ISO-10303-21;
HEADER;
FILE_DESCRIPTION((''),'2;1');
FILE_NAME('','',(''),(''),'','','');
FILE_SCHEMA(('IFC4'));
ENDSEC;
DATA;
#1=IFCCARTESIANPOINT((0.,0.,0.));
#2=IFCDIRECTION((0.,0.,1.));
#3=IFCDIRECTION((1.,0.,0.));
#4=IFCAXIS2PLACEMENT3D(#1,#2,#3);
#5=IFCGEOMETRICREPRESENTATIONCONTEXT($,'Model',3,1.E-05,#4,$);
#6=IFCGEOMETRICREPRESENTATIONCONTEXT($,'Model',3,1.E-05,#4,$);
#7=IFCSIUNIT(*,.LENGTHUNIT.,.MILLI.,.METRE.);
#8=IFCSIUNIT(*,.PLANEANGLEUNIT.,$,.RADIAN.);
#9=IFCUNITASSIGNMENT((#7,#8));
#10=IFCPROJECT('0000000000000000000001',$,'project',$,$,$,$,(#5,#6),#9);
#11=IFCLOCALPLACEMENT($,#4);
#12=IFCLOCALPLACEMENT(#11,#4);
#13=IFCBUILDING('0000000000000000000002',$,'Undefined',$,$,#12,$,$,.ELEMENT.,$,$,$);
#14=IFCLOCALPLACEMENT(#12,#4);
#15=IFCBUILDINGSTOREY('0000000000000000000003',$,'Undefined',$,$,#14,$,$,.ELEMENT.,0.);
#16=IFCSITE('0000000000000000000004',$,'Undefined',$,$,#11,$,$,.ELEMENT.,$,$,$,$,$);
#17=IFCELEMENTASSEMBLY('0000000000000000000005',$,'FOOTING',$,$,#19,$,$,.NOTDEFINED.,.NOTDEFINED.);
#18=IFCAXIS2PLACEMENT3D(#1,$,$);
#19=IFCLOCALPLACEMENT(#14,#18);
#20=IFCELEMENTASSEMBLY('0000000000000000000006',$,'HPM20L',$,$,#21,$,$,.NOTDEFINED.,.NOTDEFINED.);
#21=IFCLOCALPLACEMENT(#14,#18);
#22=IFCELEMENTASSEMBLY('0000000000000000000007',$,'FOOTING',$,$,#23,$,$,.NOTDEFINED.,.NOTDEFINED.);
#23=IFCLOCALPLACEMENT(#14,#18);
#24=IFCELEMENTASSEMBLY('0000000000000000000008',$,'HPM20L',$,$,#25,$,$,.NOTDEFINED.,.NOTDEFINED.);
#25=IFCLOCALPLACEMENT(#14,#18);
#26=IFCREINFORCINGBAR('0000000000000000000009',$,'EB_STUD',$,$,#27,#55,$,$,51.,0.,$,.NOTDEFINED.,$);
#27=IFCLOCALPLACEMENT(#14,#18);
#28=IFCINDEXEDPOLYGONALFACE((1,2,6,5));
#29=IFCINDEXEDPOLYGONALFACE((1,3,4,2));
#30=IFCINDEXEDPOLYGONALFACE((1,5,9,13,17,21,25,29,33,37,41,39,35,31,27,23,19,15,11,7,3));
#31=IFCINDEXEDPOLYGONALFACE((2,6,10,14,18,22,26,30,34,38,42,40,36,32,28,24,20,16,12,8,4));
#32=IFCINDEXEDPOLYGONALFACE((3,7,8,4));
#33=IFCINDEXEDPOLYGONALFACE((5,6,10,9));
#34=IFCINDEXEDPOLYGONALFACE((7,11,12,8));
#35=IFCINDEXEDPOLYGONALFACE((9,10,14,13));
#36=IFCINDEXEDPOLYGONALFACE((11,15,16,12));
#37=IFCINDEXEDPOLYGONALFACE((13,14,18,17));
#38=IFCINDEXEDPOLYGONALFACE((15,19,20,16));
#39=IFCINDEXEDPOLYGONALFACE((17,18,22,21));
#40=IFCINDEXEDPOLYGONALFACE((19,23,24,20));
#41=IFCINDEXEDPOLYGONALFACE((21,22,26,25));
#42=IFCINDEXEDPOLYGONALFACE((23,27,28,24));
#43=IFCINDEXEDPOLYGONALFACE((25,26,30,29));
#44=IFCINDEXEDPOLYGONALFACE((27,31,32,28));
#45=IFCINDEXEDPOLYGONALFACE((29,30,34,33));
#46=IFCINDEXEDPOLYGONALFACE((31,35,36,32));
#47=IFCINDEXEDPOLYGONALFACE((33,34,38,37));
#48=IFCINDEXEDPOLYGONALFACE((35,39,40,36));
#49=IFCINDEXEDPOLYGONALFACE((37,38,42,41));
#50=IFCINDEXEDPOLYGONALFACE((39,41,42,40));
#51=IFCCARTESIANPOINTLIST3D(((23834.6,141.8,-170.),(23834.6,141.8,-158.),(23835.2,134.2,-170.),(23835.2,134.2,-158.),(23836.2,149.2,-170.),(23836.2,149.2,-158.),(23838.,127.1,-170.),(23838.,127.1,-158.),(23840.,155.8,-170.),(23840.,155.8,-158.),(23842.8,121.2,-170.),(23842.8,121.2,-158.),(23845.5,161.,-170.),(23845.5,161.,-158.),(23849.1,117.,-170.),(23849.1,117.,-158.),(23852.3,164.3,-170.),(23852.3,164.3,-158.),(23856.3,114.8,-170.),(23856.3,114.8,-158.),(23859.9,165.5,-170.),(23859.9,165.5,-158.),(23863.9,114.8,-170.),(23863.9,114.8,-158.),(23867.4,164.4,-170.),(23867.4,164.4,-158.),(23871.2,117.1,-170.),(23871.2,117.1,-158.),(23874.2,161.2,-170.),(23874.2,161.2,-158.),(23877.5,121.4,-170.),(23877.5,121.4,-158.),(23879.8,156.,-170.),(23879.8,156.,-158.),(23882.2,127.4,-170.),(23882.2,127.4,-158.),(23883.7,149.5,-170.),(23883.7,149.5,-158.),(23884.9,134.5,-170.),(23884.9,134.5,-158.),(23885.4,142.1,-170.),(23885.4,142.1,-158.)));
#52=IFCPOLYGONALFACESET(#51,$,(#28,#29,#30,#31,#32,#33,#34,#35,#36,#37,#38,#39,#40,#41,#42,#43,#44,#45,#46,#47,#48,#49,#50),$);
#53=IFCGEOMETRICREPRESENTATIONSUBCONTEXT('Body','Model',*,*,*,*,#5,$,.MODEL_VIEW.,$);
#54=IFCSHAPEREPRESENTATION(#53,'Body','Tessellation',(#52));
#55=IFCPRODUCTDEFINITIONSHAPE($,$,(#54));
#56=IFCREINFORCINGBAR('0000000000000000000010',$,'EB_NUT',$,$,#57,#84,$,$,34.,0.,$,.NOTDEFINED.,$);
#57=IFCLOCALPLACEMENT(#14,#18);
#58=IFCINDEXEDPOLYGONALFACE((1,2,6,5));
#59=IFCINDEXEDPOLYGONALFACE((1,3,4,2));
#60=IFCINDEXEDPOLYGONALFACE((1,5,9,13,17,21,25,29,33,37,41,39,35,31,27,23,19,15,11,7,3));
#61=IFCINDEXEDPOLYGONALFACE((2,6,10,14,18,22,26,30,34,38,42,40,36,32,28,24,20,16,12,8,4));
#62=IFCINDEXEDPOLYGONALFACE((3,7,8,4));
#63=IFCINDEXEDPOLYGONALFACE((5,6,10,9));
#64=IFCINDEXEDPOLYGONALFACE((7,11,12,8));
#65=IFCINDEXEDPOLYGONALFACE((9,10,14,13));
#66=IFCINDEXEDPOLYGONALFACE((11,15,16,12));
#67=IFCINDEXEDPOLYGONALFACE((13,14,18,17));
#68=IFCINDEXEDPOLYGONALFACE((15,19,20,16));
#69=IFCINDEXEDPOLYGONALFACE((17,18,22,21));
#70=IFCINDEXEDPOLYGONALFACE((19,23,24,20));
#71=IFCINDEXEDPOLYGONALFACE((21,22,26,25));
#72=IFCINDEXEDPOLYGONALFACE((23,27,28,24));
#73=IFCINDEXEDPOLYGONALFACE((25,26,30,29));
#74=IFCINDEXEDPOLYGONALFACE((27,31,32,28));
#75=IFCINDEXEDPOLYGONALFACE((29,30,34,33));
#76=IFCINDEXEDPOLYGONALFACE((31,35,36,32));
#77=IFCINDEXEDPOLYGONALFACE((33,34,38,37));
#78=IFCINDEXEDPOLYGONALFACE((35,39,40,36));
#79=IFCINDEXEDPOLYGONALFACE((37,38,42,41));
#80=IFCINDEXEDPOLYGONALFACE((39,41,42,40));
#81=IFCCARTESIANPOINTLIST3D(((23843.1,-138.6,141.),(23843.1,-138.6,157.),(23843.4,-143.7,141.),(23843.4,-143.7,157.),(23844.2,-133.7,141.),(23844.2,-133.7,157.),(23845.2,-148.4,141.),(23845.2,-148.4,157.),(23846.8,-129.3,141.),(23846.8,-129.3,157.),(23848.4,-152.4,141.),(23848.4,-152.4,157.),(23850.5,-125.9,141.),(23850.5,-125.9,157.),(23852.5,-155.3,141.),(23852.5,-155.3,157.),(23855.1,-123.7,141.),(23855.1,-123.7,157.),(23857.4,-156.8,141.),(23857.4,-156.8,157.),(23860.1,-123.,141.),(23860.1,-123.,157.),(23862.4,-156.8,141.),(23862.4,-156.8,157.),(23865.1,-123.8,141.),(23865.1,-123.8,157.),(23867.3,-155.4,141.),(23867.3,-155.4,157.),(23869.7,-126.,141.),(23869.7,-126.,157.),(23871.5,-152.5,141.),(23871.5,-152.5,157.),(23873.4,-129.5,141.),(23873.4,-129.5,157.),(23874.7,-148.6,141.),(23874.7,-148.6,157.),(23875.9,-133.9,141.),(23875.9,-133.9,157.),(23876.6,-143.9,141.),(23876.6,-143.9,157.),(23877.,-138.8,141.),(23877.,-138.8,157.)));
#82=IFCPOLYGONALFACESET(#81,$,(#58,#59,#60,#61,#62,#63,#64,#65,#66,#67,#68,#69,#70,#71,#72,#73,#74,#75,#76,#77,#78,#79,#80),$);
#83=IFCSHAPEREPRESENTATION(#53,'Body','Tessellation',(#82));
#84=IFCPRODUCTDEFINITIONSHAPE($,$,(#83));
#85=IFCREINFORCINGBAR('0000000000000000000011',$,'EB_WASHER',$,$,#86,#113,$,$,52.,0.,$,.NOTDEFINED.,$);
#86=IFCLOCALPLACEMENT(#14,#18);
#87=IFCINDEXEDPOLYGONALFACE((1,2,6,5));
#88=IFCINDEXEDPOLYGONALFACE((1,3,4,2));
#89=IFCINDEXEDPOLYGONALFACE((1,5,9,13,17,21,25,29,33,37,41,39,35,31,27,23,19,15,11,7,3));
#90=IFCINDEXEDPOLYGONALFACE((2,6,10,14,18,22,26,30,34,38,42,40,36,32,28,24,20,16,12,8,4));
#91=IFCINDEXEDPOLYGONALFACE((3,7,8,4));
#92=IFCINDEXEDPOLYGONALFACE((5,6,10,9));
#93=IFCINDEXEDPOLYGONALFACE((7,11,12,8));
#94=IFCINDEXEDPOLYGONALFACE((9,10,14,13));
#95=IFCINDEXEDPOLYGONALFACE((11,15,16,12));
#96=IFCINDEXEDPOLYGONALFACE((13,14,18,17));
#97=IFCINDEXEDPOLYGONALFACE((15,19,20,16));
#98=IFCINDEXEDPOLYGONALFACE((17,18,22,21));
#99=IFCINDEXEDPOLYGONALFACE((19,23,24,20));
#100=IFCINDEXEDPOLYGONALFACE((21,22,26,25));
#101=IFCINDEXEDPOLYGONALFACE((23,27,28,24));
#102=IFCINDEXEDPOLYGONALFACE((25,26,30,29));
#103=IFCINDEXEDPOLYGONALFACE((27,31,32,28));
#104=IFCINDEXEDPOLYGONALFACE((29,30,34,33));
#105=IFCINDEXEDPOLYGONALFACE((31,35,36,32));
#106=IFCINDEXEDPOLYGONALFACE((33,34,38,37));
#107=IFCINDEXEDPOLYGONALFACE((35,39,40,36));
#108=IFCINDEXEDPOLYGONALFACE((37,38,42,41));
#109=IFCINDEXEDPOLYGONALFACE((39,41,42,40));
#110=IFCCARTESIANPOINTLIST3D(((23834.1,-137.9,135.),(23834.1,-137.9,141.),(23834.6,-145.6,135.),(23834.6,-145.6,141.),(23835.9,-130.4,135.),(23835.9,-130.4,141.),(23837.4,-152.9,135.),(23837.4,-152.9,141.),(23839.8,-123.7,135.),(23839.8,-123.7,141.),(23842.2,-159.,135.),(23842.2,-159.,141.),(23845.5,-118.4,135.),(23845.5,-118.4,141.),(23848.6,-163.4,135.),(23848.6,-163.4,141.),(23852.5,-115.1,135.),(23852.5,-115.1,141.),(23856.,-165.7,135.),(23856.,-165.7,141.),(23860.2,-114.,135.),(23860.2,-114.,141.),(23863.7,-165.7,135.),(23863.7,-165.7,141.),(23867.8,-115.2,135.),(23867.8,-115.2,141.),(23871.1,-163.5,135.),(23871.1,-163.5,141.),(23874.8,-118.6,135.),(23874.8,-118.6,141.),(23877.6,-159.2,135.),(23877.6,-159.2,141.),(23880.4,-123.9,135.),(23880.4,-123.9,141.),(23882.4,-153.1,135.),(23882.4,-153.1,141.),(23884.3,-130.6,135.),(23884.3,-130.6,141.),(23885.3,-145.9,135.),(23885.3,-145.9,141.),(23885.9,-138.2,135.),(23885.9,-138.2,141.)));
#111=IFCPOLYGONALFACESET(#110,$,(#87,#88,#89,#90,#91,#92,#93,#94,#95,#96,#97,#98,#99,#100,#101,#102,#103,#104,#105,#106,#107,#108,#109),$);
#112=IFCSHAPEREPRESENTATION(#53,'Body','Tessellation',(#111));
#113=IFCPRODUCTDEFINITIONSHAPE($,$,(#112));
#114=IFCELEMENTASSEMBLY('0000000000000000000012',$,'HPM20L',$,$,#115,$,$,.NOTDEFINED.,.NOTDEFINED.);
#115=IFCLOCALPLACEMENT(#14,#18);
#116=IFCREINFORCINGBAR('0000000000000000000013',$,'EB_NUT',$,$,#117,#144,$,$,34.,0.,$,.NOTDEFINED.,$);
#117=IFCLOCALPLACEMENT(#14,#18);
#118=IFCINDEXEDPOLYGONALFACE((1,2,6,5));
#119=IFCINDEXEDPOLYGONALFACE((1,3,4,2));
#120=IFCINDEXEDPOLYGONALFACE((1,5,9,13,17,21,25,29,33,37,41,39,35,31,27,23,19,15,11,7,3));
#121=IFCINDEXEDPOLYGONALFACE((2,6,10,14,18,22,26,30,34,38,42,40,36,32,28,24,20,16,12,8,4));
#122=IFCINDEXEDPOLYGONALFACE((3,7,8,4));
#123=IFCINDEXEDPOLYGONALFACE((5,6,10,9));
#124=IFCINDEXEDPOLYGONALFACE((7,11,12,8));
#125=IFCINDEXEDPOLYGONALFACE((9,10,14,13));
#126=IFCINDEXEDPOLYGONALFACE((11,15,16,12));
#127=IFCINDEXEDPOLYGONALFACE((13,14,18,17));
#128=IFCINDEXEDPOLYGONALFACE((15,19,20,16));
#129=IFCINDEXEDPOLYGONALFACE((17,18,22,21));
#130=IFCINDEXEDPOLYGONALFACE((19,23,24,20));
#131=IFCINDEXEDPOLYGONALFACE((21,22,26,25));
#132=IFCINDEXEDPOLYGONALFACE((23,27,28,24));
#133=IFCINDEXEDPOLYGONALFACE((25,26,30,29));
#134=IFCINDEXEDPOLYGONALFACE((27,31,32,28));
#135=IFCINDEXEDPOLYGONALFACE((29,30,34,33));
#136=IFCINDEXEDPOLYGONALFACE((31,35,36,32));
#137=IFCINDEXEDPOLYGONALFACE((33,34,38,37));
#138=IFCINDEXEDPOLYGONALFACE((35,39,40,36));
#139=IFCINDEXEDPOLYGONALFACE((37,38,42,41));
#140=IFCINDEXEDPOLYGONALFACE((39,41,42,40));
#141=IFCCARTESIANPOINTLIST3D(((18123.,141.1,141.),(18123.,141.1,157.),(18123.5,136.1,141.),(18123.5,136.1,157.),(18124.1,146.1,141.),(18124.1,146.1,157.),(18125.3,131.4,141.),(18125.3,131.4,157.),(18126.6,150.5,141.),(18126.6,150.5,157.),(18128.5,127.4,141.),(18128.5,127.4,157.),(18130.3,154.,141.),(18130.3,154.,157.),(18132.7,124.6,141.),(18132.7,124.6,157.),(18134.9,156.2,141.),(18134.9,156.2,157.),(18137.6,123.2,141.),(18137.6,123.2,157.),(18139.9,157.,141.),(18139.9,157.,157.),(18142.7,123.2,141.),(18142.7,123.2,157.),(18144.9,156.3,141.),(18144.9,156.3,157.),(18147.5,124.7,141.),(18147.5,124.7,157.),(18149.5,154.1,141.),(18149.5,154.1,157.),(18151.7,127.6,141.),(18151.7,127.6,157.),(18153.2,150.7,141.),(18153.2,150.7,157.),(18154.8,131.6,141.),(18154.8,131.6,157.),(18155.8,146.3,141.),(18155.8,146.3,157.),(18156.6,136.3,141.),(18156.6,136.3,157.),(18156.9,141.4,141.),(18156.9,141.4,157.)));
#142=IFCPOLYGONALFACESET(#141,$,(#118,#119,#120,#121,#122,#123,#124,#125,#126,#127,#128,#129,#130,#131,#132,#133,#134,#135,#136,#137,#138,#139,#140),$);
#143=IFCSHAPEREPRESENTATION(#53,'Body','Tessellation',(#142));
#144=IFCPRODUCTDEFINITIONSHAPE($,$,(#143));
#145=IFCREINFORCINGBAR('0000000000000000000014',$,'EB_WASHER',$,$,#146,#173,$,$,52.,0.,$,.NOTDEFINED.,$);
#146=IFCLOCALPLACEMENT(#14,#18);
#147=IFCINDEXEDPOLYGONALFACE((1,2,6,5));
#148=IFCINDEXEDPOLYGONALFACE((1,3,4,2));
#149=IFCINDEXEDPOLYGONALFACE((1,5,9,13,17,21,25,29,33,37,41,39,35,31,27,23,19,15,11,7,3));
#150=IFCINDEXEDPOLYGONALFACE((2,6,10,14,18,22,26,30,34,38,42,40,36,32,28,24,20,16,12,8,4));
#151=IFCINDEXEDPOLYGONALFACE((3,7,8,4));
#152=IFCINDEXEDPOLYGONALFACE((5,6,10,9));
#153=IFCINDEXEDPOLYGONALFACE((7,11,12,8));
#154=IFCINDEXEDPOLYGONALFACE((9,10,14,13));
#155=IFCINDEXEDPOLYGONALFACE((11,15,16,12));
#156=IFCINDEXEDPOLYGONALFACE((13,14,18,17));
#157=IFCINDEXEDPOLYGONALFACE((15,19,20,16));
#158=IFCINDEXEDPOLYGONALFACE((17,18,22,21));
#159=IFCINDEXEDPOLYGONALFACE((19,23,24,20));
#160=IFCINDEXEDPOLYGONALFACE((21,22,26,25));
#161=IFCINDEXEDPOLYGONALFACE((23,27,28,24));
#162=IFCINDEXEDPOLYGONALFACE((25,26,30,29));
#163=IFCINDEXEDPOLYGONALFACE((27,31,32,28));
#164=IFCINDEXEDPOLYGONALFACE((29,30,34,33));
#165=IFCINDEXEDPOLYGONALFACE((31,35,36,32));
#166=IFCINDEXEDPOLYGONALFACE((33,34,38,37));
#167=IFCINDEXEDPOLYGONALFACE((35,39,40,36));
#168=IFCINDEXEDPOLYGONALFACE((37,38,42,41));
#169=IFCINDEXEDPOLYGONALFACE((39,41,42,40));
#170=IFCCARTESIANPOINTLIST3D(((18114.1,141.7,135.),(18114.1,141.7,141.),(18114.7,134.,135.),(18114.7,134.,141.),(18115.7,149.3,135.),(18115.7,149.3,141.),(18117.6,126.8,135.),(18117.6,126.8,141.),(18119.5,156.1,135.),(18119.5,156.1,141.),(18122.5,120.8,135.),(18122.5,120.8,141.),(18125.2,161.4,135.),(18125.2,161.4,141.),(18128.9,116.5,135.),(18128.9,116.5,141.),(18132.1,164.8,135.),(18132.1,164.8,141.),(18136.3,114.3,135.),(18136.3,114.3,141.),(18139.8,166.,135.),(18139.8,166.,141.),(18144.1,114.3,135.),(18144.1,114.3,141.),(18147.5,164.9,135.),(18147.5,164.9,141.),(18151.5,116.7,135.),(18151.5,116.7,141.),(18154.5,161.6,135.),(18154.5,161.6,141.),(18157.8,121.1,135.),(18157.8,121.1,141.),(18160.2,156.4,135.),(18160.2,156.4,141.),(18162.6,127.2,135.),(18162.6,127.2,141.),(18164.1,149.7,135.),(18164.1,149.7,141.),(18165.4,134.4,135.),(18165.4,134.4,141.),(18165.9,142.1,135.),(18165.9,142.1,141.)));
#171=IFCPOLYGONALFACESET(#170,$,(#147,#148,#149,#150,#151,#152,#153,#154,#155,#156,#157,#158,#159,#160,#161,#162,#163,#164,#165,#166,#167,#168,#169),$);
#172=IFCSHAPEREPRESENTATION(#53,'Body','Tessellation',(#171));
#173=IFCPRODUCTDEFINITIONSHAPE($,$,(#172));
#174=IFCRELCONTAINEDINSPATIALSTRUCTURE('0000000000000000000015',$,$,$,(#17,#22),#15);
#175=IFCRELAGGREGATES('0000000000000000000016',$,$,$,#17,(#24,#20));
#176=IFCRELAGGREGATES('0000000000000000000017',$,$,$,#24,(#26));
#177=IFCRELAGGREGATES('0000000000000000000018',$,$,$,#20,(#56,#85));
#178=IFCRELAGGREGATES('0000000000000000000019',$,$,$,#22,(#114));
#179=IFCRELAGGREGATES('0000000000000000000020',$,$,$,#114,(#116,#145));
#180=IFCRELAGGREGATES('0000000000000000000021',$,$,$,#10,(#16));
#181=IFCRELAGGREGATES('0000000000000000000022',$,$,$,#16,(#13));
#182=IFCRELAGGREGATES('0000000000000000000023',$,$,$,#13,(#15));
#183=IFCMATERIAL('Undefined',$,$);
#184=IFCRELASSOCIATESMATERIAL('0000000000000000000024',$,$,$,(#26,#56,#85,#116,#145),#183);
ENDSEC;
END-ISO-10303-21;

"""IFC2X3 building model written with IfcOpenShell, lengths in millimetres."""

from ifc_helpers import new_model, entity, si_unit, frame, origin_with_axes, place, context, subcontext, project, spatial, source, transform, mapped, material, element, aggregate, save


model = new_model("IFC2X3")

# Units and contexts
model_context_1 = context("Model", 3, precision=1e-05, world=origin_with_axes())
model_context_2 = context("Model", 3, precision=1e-05, world=origin_with_axes())
body_context = subcontext(model_context_1, "Body", "Model", "MODEL_VIEW")
ifc_project = project(units=[si_unit("LENGTHUNIT", "METRE", prefix="MILLI"), si_unit("PLANEANGLEUNIT", "RADIAN")], contexts=[model_context_1, model_context_2])

# Site, building, storey
site_placement = place(None, origin_with_axes())
site = spatial("IfcSite", under=ifc_project, at=site_placement, Name="Undefined", CompositionType="ELEMENT")
building_placement = place(site_placement, origin_with_axes())
building = spatial("IfcBuilding", under=site, at=building_placement, Name="Undefined", CompositionType="ELEMENT")
storey_placement = place(building_placement, origin_with_axes())
storey = spatial("IfcBuildingStorey", under=building, at=storey_placement, Name="Undefined", CompositionType="ELEMENT", Elevation=0.0)

# Element assemblies
assembly_1_placement = place(storey_placement, origin_with_axes())
assembly_1 = element("IfcElementAssembly", 1, at=assembly_1_placement, inside=storey, Name="FOOTING", AssemblyPlace="NOTDEFINED", PredefinedType="NOTDEFINED")
assembly_2_placement = place(assembly_1_placement, origin_with_axes())
assembly_2 = element("IfcElementAssembly", 2, at=assembly_2_placement, Name="HPM20L", AssemblyPlace="NOTDEFINED", PredefinedType="NOTDEFINED")
assembly_3_placement = place(storey_placement, origin_with_axes())
assembly_3 = element("IfcElementAssembly", 3, at=assembly_3_placement, inside=storey, Name="FOOTING", AssemblyPlace="NOTDEFINED", PredefinedType="NOTDEFINED")

# Shared definitions
ifc_material_1 = material(Name="Undefined")

# Element assembly
assembly_4_placement = place(assembly_1_placement, origin_with_axes())
assembly_4 = element("IfcElementAssembly", 4, at=assembly_4_placement, Name="HPM20L", AssemblyPlace="NOTDEFINED", PredefinedType="NOTDEFINED")
aggregate(assembly_1, [assembly_4, assembly_2])

# Reinforcing bars
shared_shape_1 = source(origin_with_axes(), body_context, "Body", "AdvancedSweptSolid", [
    entity("IfcSweptDiskSolid", entity("IfcTrimmedCurve", entity("IfcLine", entity("IfcCartesianPoint", [0.0, 0.0, 0.0]), entity("IfcVector", entity("IfcDirection", [1.0, 0.0, 0.0]), 1.0)), [entity("IfcParameterValue", 0.0)], [entity("IfcParameterValue", 12.0)], True, "PARAMETER"), 25.5, None, 0.0, 12.0),
])
reinforcing_bar_1_placement = place(assembly_4_placement, frame((23860.0, 140.0, -158.0), z_axis=(-0.005867, 0.999983, 0.0), x_axis=(0.0, 0.0, -1.0)))
reinforcing_bar_1 = element("IfcReinforcingBar", 5, at=reinforcing_bar_1_placement, material=ifc_material_1, Name="EB_STUD", BarRole="NOTDEFINED", CrossSectionArea=0.0, NominalDiameter=51.0, context=body_context, shape_type="MappedRepresentation", body=[
    mapped(shared_shape_1, transform((0.0, 0.0, 0.0))),
])
aggregate(assembly_4, [reinforcing_bar_1])
shared_shape_2 = source(origin_with_axes(), body_context, "Body", "AdvancedSweptSolid", [
    entity("IfcSweptDiskSolid", entity("IfcTrimmedCurve", entity("IfcLine", entity("IfcCartesianPoint", [0.0, 0.0, 0.0]), entity("IfcVector", entity("IfcDirection", [1.0, 0.0, 0.0]), 1.0)), [entity("IfcParameterValue", 0.0)], [entity("IfcParameterValue", 16.0)], True, "PARAMETER"), 17.0, None, 0.0, 16.0),
])
reinforcing_bar_2_placement = place(assembly_2_placement, frame((23860.0, -140.0, 157.0), z_axis=(0.005867, 0.999983, 0.0), x_axis=(0.0, 0.0, -1.0)))
reinforcing_bar_2 = element("IfcReinforcingBar", 6, at=reinforcing_bar_2_placement, material=ifc_material_1, Name="EB_NUT", BarRole="NOTDEFINED", CrossSectionArea=0.0, NominalDiameter=34.0, context=body_context, shape_type="MappedRepresentation", body=[
    mapped(shared_shape_2, transform((0.0, 0.0, 0.0))),
])
shared_shape_3 = source(origin_with_axes(), body_context, "Body", "AdvancedSweptSolid", [
    entity("IfcSweptDiskSolid", entity("IfcTrimmedCurve", entity("IfcLine", entity("IfcCartesianPoint", [0.0, 0.0, 0.0]), entity("IfcVector", entity("IfcDirection", [1.0, 0.0, 0.0]), 1.0)), [entity("IfcParameterValue", 0.0)], [entity("IfcParameterValue", 6.0)], True, "PARAMETER"), 26.0, None, 0.0, 6.0),
])
reinforcing_bar_3_placement = place(assembly_2_placement, frame((23860.0, -140.0, 141.0), z_axis=(0.005867, 0.999983, 0.0), x_axis=(0.0, 0.0, -1.0)))
reinforcing_bar_3 = element("IfcReinforcingBar", 7, at=reinforcing_bar_3_placement, material=ifc_material_1, Name="EB_WASHER", BarRole="NOTDEFINED", CrossSectionArea=0.0, NominalDiameter=52.0, context=body_context, shape_type="MappedRepresentation", body=[
    mapped(shared_shape_3, transform((0.0, 0.0, 0.0))),
])
aggregate(assembly_2, [reinforcing_bar_2, reinforcing_bar_3])

# Element assembly
assembly_5_placement = place(assembly_3_placement, origin_with_axes())
assembly_5 = element("IfcElementAssembly", 8, at=assembly_5_placement, Name="HPM20L", AssemblyPlace="NOTDEFINED", PredefinedType="NOTDEFINED")
aggregate(assembly_3, [assembly_5])

# Reinforcing bars
shared_shape_4 = source(origin_with_axes(), body_context, "Body", "AdvancedSweptSolid", [
    entity("IfcSweptDiskSolid", entity("IfcTrimmedCurve", entity("IfcLine", entity("IfcCartesianPoint", [0.0, 0.0, 0.0]), entity("IfcVector", entity("IfcDirection", [1.0, 0.0, 0.0]), 1.0)), [entity("IfcParameterValue", 0.0)], [entity("IfcParameterValue", 16.0)], True, "PARAMETER"), 17.0, None, 0.0, 16.0),
])
reinforcing_bar_4_placement = place(assembly_5_placement, frame((18140.0, 140.0, 157.0), z_axis=(-0.007718, 0.99997, 0.0), x_axis=(0.0, 0.0, -1.0)))
reinforcing_bar_4 = element("IfcReinforcingBar", 9, at=reinforcing_bar_4_placement, material=ifc_material_1, Name="EB_NUT", BarRole="NOTDEFINED", CrossSectionArea=0.0, NominalDiameter=34.0, context=body_context, shape_type="MappedRepresentation", body=[
    mapped(shared_shape_4, transform((0.0, 0.0, 0.0))),
])
shared_shape_5 = source(origin_with_axes(), body_context, "Body", "AdvancedSweptSolid", [
    entity("IfcSweptDiskSolid", entity("IfcTrimmedCurve", entity("IfcLine", entity("IfcCartesianPoint", [0.0, 0.0, 0.0]), entity("IfcVector", entity("IfcDirection", [1.0, 0.0, 0.0]), 1.0)), [entity("IfcParameterValue", 0.0)], [entity("IfcParameterValue", 6.0)], True, "PARAMETER"), 26.0, None, 0.0, 6.0),
])
reinforcing_bar_5_placement = place(assembly_5_placement, frame((18140.0, 140.0, 141.0), z_axis=(-0.007718, 0.99997, 0.0), x_axis=(0.0, 0.0, -1.0)))
reinforcing_bar_5 = element("IfcReinforcingBar", 10, at=reinforcing_bar_5_placement, material=ifc_material_1, Name="EB_WASHER", BarRole="NOTDEFINED", CrossSectionArea=0.0, NominalDiameter=52.0, context=body_context, shape_type="MappedRepresentation", body=[
    mapped(shared_shape_5, transform((0.0, 0.0, 0.0))),
])
aggregate(assembly_5, [reinforcing_bar_4, reinforcing_bar_5])

save(model, "model.ifc")
